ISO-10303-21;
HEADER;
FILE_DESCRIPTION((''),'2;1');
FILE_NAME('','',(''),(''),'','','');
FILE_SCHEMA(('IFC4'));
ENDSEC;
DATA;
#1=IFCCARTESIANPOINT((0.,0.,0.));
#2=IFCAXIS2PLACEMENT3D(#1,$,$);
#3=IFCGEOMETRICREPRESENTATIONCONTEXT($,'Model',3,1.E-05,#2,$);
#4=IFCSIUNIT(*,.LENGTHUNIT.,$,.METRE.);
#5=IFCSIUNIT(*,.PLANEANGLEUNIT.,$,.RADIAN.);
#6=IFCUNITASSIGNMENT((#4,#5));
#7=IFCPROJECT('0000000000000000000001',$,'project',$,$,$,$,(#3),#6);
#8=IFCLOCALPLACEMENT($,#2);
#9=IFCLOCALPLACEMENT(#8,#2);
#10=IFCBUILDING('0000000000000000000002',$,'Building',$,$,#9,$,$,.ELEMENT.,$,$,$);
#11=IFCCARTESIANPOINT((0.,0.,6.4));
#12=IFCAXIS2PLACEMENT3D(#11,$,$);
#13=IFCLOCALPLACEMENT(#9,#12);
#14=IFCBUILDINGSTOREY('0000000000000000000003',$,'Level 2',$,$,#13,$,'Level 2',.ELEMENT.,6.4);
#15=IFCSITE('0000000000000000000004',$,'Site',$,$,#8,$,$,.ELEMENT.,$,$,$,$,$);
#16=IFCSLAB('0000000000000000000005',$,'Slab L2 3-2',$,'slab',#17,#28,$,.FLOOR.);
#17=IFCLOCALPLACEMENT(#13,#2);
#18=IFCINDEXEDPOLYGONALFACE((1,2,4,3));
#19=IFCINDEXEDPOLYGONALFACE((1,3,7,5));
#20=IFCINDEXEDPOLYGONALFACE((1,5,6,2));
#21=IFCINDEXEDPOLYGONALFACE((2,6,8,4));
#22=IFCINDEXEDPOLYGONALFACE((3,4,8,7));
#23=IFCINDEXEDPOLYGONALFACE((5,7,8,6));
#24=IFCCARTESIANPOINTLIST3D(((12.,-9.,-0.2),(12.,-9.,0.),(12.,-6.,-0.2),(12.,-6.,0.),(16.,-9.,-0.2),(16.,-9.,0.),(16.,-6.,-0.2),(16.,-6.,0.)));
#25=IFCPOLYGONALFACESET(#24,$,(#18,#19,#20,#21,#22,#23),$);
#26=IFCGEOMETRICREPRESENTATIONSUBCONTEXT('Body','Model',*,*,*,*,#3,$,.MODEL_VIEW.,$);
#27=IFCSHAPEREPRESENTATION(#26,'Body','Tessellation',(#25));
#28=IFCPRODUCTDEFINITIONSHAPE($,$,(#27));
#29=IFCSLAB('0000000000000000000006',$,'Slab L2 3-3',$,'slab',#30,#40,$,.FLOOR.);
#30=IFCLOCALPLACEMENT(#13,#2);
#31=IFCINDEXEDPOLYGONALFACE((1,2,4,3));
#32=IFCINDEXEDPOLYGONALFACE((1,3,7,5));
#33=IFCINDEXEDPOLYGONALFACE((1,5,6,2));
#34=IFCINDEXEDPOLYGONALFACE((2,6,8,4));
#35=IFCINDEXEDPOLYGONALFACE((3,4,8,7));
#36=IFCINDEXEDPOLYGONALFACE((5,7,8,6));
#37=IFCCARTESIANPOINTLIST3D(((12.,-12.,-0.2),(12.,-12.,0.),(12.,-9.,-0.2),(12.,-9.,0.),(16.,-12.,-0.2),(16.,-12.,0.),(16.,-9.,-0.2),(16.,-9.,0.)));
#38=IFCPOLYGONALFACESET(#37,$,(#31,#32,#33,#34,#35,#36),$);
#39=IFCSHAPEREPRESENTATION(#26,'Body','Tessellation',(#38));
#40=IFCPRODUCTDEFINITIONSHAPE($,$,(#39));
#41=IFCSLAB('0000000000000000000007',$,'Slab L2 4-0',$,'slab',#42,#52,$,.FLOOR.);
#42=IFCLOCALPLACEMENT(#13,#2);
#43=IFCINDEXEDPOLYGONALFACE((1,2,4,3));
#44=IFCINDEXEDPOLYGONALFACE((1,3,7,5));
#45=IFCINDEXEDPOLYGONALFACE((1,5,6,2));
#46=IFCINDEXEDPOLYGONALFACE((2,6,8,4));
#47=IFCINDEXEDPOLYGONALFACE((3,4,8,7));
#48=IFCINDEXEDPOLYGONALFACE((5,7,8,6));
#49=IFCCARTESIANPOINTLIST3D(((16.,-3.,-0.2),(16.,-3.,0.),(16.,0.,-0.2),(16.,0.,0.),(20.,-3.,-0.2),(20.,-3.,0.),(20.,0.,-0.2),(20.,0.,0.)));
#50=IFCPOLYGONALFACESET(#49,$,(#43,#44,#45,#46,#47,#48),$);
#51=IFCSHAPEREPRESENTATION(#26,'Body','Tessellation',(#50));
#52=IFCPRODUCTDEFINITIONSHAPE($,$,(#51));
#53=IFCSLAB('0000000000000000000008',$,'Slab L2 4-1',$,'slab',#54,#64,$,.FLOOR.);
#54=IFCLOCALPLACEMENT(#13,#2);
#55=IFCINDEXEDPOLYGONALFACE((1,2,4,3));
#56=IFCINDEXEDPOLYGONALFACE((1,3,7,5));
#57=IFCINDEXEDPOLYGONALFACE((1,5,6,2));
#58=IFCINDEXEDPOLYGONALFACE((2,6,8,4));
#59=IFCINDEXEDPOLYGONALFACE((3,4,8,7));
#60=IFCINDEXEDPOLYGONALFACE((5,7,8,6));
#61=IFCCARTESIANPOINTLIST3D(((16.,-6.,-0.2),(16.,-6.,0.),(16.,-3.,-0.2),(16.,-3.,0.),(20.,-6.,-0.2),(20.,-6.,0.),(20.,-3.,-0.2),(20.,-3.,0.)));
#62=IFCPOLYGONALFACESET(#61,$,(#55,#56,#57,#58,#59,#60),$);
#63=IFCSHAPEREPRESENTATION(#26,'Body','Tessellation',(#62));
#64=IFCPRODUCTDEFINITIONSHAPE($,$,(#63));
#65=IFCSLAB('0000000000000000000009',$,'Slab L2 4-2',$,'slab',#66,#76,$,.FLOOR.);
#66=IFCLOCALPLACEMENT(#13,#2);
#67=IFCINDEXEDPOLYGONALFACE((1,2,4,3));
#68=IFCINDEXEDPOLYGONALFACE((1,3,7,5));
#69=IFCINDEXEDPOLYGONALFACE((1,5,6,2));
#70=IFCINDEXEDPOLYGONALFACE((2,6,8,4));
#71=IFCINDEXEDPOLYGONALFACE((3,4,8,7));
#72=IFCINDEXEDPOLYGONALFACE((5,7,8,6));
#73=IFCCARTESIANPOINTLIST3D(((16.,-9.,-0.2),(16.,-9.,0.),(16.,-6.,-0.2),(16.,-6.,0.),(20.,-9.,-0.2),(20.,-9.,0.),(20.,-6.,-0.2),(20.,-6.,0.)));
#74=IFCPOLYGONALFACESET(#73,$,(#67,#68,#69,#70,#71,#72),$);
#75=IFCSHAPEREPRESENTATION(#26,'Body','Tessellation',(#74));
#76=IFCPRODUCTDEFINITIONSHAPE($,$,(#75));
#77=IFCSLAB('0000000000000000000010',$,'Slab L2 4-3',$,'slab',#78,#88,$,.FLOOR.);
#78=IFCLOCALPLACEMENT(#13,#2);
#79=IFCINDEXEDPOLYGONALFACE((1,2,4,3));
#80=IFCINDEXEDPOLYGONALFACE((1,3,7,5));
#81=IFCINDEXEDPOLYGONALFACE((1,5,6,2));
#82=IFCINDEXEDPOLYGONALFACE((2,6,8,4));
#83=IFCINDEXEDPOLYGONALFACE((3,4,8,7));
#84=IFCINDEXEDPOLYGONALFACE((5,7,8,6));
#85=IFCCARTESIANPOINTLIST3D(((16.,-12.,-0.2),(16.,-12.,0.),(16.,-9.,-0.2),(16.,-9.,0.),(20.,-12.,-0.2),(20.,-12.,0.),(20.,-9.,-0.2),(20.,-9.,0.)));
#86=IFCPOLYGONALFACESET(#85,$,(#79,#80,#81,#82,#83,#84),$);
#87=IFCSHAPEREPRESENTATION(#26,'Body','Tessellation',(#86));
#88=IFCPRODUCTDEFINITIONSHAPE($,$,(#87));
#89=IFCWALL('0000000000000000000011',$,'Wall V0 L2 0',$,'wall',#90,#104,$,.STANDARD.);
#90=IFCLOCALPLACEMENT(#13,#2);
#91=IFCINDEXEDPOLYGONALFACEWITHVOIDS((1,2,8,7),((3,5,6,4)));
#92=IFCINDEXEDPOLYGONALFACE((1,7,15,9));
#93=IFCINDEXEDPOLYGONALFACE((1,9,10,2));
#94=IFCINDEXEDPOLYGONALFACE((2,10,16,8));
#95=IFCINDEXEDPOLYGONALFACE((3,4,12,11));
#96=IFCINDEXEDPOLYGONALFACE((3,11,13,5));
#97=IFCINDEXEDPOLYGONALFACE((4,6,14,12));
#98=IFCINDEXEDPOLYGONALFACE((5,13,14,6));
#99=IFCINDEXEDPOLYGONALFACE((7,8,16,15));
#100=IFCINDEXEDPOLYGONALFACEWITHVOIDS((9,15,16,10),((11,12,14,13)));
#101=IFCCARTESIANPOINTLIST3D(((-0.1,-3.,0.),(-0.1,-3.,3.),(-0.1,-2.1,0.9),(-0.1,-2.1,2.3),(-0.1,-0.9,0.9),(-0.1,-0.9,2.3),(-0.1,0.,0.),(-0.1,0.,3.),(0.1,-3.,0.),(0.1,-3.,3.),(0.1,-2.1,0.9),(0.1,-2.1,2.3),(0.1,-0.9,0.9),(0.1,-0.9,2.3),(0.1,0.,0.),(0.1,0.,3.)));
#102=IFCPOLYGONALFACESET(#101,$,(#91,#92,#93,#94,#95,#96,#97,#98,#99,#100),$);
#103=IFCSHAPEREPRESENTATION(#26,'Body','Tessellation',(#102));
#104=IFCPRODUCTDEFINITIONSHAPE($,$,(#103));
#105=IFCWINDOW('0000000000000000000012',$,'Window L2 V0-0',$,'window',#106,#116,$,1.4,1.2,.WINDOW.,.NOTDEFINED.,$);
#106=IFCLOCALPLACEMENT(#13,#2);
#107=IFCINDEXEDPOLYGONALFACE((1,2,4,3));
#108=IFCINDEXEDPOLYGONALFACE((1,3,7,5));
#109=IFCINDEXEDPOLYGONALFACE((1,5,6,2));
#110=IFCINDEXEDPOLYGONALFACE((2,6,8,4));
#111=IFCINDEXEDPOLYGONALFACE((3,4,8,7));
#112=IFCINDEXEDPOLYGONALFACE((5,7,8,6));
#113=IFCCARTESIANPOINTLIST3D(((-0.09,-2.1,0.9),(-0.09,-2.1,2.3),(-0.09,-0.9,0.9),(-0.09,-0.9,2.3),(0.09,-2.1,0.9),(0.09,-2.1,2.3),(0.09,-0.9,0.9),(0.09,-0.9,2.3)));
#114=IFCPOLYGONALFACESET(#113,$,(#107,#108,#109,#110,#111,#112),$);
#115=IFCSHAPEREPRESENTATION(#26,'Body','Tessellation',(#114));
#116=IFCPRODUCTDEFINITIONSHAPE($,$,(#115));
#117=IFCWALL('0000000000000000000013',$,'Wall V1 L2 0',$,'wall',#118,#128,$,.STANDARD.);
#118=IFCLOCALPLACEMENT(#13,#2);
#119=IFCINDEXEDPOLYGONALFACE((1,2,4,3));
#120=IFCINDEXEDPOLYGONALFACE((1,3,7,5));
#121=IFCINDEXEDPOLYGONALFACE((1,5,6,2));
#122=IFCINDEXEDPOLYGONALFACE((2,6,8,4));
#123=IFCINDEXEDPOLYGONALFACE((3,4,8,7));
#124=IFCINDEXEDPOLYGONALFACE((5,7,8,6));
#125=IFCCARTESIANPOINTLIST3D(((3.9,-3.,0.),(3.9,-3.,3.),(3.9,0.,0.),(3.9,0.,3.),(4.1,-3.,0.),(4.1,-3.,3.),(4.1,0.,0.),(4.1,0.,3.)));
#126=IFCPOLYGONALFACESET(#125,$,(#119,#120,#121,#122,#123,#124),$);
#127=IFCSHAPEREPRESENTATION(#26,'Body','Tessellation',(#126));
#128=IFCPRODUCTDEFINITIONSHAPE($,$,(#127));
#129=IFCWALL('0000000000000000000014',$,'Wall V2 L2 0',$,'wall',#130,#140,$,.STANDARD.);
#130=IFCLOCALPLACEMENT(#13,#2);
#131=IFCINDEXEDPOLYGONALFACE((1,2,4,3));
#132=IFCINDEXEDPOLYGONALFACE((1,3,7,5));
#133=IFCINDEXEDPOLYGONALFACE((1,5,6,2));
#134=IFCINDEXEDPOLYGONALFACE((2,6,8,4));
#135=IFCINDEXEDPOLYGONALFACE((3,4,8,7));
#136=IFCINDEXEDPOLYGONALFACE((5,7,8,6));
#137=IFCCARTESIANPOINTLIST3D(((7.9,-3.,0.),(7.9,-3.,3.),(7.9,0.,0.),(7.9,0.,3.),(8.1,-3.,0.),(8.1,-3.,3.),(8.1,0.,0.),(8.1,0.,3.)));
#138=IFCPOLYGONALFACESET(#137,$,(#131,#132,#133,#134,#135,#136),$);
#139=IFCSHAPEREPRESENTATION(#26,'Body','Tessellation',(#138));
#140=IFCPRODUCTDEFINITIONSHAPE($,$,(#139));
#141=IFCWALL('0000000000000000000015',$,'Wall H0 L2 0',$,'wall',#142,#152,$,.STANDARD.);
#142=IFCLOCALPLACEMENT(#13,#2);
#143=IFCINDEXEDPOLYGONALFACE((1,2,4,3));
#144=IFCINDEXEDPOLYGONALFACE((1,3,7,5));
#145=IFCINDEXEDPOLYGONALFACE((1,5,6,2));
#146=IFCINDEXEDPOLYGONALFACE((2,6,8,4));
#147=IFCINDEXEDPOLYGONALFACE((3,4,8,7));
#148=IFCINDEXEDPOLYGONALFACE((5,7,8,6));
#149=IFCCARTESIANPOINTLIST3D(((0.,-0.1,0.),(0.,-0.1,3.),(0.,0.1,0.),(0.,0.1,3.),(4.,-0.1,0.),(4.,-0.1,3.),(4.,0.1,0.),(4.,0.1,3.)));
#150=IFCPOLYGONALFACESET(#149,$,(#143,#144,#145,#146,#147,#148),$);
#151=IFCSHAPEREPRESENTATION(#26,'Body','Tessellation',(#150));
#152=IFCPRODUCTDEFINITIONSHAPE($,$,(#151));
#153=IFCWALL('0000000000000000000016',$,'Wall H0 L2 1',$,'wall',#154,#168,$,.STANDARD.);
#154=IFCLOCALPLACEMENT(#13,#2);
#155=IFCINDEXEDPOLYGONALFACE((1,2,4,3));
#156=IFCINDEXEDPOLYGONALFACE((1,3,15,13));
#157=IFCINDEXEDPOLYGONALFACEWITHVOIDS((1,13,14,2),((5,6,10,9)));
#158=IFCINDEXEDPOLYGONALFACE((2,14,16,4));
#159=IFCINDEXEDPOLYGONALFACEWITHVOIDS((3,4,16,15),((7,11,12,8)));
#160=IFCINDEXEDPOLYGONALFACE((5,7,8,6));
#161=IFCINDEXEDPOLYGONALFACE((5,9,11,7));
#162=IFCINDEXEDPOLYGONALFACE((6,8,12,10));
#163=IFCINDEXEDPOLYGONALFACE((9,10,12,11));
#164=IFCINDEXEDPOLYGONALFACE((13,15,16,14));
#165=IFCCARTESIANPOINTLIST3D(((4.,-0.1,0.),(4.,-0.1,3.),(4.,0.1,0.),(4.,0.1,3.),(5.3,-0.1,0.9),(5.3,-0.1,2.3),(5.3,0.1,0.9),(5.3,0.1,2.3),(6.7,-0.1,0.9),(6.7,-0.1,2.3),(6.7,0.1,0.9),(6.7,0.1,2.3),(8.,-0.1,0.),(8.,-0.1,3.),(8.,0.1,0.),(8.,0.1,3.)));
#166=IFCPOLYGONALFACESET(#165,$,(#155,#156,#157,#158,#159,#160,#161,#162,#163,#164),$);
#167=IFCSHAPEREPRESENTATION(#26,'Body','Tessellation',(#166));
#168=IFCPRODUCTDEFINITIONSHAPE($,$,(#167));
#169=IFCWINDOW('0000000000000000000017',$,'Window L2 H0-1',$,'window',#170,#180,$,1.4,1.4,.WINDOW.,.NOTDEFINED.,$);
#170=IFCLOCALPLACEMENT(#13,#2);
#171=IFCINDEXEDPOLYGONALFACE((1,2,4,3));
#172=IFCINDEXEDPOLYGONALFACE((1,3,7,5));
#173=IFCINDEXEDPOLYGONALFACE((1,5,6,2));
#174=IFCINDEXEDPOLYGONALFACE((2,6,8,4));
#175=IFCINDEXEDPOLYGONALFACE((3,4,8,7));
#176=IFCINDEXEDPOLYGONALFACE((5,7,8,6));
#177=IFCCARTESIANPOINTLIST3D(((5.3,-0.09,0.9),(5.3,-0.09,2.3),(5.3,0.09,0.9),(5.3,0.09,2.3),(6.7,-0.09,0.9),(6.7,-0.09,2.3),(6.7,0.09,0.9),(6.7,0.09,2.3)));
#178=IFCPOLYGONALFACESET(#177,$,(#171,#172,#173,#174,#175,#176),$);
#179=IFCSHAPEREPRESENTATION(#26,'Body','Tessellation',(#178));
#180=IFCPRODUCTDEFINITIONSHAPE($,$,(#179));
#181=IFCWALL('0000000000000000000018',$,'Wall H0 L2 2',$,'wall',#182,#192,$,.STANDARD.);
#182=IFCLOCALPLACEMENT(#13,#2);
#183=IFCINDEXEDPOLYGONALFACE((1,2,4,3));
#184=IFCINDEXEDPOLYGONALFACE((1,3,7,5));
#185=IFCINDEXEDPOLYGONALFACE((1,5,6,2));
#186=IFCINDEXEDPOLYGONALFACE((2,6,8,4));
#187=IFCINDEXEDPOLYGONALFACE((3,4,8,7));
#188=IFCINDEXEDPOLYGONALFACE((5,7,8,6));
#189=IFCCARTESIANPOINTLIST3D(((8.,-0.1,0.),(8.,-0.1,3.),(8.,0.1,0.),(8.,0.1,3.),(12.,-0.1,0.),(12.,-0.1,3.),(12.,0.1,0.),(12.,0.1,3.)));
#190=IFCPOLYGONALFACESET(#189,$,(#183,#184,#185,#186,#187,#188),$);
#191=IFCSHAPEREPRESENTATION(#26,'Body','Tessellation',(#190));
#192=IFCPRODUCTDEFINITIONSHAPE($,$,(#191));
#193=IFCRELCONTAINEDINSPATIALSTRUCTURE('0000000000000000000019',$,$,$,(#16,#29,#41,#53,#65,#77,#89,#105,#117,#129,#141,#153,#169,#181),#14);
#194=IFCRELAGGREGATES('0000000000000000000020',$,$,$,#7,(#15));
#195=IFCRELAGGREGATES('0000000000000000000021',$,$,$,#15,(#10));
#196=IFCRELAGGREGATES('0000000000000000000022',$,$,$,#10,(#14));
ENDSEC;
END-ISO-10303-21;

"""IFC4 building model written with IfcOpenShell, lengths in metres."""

from ifc_helpers import new_model, si_unit, frame, frame_2d, origin, origin_with_axes, origin_2d, place, context, subcontext, project, spatial, polyline, rectangle, outline, extrude, element, fill, save


model = new_model("IFC4")

# Units and contexts
model_context = context("Model", 3, precision=1e-05, world=origin())
body_context = subcontext(model_context, "Body", "Model", "MODEL_VIEW")
ifc_project = project(units=[si_unit("LENGTHUNIT", "METRE"), si_unit("PLANEANGLEUNIT", "RADIAN")], contexts=[model_context])

# Site, building, storey
site_placement = place(None, origin())
site = spatial("IfcSite", under=ifc_project, at=site_placement, Name="Site", CompositionType="ELEMENT")
building_placement = place(site_placement, origin())
building = spatial("IfcBuilding", under=site, at=building_placement, Name="Building", CompositionType="ELEMENT")
storey_placement = place(building_placement, frame((0.0, 0.0, 6.4)))
storey = spatial("IfcBuildingStorey", under=building, at=storey_placement, Name="Level 2", LongName="Level 2", CompositionType="ELEMENT", Elevation=6.4)

# Slabs
slab_1_placement = place(storey_placement, frame((0.0, 0.0, -0.2)))
element("IfcSlab", 1, at=slab_1_placement, inside=storey, Name="Slab L2 3-2", ObjectType="slab", PredefinedType="FLOOR", context=body_context, shape_type="SweptSolid", body=[
    extrude(outline(polyline([(12.0, -9.0), (16.0, -9.0), (16.0, -6.0), (12.0, -6.0), (12.0, -9.0)])), origin(), (0.0, 0.0, 1.0), 0.2),
])
slab_2_placement = place(storey_placement, frame((0.0, 0.0, -0.2)))
element("IfcSlab", 2, at=slab_2_placement, inside=storey, Name="Slab L2 3-3", ObjectType="slab", PredefinedType="FLOOR", context=body_context, shape_type="SweptSolid", body=[
    extrude(outline(polyline([(12.0, -12.0), (16.0, -12.0), (16.0, -9.0), (12.0, -9.0), (12.0, -12.0)])), origin(), (0.0, 0.0, 1.0), 0.2),
])
slab_3_placement = place(storey_placement, frame((0.0, 0.0, -0.2)))
element("IfcSlab", 3, at=slab_3_placement, inside=storey, Name="Slab L2 4-0", ObjectType="slab", PredefinedType="FLOOR", context=body_context, shape_type="SweptSolid", body=[
    extrude(outline(polyline([(16.0, -3.0), (20.0, -3.0), (20.0, 0.0), (16.0, 0.0), (16.0, -3.0)])), origin(), (0.0, 0.0, 1.0), 0.2),
])
slab_4_placement = place(storey_placement, frame((0.0, 0.0, -0.2)))
element("IfcSlab", 4, at=slab_4_placement, inside=storey, Name="Slab L2 4-1", ObjectType="slab", PredefinedType="FLOOR", context=body_context, shape_type="SweptSolid", body=[
    extrude(outline(polyline([(16.0, -6.0), (20.0, -6.0), (20.0, -3.0), (16.0, -3.0), (16.0, -6.0)])), origin(), (0.0, 0.0, 1.0), 0.2),
])
slab_5_placement = place(storey_placement, frame((0.0, 0.0, -0.2)))
element("IfcSlab", 5, at=slab_5_placement, inside=storey, Name="Slab L2 4-2", ObjectType="slab", PredefinedType="FLOOR", context=body_context, shape_type="SweptSolid", body=[
    extrude(outline(polyline([(16.0, -9.0), (20.0, -9.0), (20.0, -6.0), (16.0, -6.0), (16.0, -9.0)])), origin(), (0.0, 0.0, 1.0), 0.2),
])
slab_6_placement = place(storey_placement, frame((0.0, 0.0, -0.2)))
element("IfcSlab", 6, at=slab_6_placement, inside=storey, Name="Slab L2 4-3", ObjectType="slab", PredefinedType="FLOOR", context=body_context, shape_type="SweptSolid", body=[
    extrude(outline(polyline([(16.0, -12.0), (20.0, -12.0), (20.0, -9.0), (16.0, -9.0), (16.0, -12.0)])), origin(), (0.0, 0.0, 1.0), 0.2),
])

# Wall, opening, window
wall_1_placement = place(storey_placement, frame((0.0, 0.0, 0.0), z_axis=(0.0, 0.0, 1.0), x_axis=(0.0, -1.0, 0.0)))
wall_1 = element("IfcWall", 7, at=wall_1_placement, inside=storey, Name="Wall V0 L2 0", ObjectType="wall", PredefinedType="STANDARD", context=body_context, shape_type="SweptSolid", body=[
    extrude(rectangle(XDim=3.0, YDim=0.2, at=frame_2d((1.5, 0.0))), origin(), (0.0, 0.0, 1.0), 3.0),
])
opening_1_placement = place(storey_placement, frame((0.0, -1.5, 0.9), z_axis=(0.0, 0.0, 1.0), x_axis=(0.0, -1.0, 0.0)))
opening_1 = element("IfcOpeningElement", 8, at=opening_1_placement, cuts=wall_1, ObjectType="Opening", PredefinedType="OPENING", context=body_context, shape_type="SweptSolid", body=[
    extrude(rectangle(XDim=1.2, YDim=0.22, at=origin_2d()), origin(), (0.0, 0.0, 1.0), 1.4),
])
window_1_placement = place(storey_placement, frame((0.0, -1.5, 0.9), z_axis=(0.0, 0.0, 1.0), x_axis=(0.0, -1.0, 0.0)))
window_1 = element("IfcWindow", 9, at=window_1_placement, inside=storey, Name="Window L2 V0-0", ObjectType="window", OverallHeight=1.4, OverallWidth=1.2, PartitioningType="NOTDEFINED", PredefinedType="WINDOW", context=body_context, shape_type="SweptSolid", body=[
    extrude(rectangle(XDim=1.2, YDim=0.18, at=origin_2d()), origin(), (0.0, 0.0, 1.0), 1.4),
])
fill(opening_1, window_1)

# Walls
for number, where, z_axis, x_axis, name in (
    (10, (4.0, 0.0, 0.0), (0.0, 0.0, 1.0), (0.0, -1.0, 0.0), "Wall V1 L2 0"),
    (11, (8.0, 0.0, 0.0), (0.0, 0.0, 1.0), (0.0, -1.0, 0.0), "Wall V2 L2 0"),
):
    element("IfcWall", number, at=place(storey_placement, frame(where, z_axis=z_axis, x_axis=x_axis)), inside=storey, Name=name, ObjectType="wall", PredefinedType="STANDARD", context=body_context, shape_type="SweptSolid", body=[
        extrude(rectangle(XDim=3.0, YDim=0.2, at=frame_2d((1.5, 0.0))), origin(), (0.0, 0.0, 1.0), 3.0),
    ])
wall_2_placement = place(storey_placement, origin_with_axes())
element("IfcWall", 12, at=wall_2_placement, inside=storey, Name="Wall H0 L2 0", ObjectType="wall", PredefinedType="STANDARD", context=body_context, shape_type="SweptSolid", body=[
    extrude(rectangle(XDim=4.0, YDim=0.2, at=frame_2d((2.0, 0.0))), origin(), (0.0, 0.0, 1.0), 3.0),
])

# Wall, opening, window
wall_3_placement = place(storey_placement, frame((4.0, 0.0, 0.0), z_axis=(0.0, 0.0, 1.0), x_axis=(1.0, 0.0, 0.0)))
wall_3 = element("IfcWall", 13, at=wall_3_placement, inside=storey, Name="Wall H0 L2 1", ObjectType="wall", PredefinedType="STANDARD", context=body_context, shape_type="SweptSolid", body=[
    extrude(rectangle(XDim=4.0, YDim=0.2, at=frame_2d((2.0, 0.0))), origin(), (0.0, 0.0, 1.0), 3.0),
])
opening_2_placement = place(storey_placement, frame((6.0, 0.0, 0.9), z_axis=(0.0, 0.0, 1.0), x_axis=(1.0, 0.0, 0.0)))
opening_2 = element("IfcOpeningElement", 14, at=opening_2_placement, cuts=wall_3, ObjectType="Opening", PredefinedType="OPENING", context=body_context, shape_type="SweptSolid", body=[
    extrude(rectangle(XDim=1.4, YDim=0.22, at=origin_2d()), origin(), (0.0, 0.0, 1.0), 1.4),
])
window_2_placement = place(storey_placement, frame((6.0, 0.0, 0.9), z_axis=(0.0, 0.0, 1.0), x_axis=(1.0, 0.0, 0.0)))
window_2 = element("IfcWindow", 15, at=window_2_placement, inside=storey, Name="Window L2 H0-1", ObjectType="window", OverallHeight=1.4, OverallWidth=1.4, PartitioningType="NOTDEFINED", PredefinedType="WINDOW", context=body_context, shape_type="SweptSolid", body=[
    extrude(rectangle(XDim=1.4, YDim=0.18, at=origin_2d()), origin(), (0.0, 0.0, 1.0), 1.4),
])
fill(opening_2, window_2)

# Wall
wall_4_placement = place(storey_placement, frame((8.0, 0.0, 0.0), z_axis=(0.0, 0.0, 1.0), x_axis=(1.0, 0.0, 0.0)))
element("IfcWall", 16, at=wall_4_placement, inside=storey, Name="Wall H0 L2 2", ObjectType="wall", PredefinedType="STANDARD", context=body_context, shape_type="SweptSolid", body=[
    extrude(rectangle(XDim=4.0, YDim=0.2, at=frame_2d((2.0, 0.0))), origin(), (0.0, 0.0, 1.0), 3.0),
])

save(model, "model.ifc")
